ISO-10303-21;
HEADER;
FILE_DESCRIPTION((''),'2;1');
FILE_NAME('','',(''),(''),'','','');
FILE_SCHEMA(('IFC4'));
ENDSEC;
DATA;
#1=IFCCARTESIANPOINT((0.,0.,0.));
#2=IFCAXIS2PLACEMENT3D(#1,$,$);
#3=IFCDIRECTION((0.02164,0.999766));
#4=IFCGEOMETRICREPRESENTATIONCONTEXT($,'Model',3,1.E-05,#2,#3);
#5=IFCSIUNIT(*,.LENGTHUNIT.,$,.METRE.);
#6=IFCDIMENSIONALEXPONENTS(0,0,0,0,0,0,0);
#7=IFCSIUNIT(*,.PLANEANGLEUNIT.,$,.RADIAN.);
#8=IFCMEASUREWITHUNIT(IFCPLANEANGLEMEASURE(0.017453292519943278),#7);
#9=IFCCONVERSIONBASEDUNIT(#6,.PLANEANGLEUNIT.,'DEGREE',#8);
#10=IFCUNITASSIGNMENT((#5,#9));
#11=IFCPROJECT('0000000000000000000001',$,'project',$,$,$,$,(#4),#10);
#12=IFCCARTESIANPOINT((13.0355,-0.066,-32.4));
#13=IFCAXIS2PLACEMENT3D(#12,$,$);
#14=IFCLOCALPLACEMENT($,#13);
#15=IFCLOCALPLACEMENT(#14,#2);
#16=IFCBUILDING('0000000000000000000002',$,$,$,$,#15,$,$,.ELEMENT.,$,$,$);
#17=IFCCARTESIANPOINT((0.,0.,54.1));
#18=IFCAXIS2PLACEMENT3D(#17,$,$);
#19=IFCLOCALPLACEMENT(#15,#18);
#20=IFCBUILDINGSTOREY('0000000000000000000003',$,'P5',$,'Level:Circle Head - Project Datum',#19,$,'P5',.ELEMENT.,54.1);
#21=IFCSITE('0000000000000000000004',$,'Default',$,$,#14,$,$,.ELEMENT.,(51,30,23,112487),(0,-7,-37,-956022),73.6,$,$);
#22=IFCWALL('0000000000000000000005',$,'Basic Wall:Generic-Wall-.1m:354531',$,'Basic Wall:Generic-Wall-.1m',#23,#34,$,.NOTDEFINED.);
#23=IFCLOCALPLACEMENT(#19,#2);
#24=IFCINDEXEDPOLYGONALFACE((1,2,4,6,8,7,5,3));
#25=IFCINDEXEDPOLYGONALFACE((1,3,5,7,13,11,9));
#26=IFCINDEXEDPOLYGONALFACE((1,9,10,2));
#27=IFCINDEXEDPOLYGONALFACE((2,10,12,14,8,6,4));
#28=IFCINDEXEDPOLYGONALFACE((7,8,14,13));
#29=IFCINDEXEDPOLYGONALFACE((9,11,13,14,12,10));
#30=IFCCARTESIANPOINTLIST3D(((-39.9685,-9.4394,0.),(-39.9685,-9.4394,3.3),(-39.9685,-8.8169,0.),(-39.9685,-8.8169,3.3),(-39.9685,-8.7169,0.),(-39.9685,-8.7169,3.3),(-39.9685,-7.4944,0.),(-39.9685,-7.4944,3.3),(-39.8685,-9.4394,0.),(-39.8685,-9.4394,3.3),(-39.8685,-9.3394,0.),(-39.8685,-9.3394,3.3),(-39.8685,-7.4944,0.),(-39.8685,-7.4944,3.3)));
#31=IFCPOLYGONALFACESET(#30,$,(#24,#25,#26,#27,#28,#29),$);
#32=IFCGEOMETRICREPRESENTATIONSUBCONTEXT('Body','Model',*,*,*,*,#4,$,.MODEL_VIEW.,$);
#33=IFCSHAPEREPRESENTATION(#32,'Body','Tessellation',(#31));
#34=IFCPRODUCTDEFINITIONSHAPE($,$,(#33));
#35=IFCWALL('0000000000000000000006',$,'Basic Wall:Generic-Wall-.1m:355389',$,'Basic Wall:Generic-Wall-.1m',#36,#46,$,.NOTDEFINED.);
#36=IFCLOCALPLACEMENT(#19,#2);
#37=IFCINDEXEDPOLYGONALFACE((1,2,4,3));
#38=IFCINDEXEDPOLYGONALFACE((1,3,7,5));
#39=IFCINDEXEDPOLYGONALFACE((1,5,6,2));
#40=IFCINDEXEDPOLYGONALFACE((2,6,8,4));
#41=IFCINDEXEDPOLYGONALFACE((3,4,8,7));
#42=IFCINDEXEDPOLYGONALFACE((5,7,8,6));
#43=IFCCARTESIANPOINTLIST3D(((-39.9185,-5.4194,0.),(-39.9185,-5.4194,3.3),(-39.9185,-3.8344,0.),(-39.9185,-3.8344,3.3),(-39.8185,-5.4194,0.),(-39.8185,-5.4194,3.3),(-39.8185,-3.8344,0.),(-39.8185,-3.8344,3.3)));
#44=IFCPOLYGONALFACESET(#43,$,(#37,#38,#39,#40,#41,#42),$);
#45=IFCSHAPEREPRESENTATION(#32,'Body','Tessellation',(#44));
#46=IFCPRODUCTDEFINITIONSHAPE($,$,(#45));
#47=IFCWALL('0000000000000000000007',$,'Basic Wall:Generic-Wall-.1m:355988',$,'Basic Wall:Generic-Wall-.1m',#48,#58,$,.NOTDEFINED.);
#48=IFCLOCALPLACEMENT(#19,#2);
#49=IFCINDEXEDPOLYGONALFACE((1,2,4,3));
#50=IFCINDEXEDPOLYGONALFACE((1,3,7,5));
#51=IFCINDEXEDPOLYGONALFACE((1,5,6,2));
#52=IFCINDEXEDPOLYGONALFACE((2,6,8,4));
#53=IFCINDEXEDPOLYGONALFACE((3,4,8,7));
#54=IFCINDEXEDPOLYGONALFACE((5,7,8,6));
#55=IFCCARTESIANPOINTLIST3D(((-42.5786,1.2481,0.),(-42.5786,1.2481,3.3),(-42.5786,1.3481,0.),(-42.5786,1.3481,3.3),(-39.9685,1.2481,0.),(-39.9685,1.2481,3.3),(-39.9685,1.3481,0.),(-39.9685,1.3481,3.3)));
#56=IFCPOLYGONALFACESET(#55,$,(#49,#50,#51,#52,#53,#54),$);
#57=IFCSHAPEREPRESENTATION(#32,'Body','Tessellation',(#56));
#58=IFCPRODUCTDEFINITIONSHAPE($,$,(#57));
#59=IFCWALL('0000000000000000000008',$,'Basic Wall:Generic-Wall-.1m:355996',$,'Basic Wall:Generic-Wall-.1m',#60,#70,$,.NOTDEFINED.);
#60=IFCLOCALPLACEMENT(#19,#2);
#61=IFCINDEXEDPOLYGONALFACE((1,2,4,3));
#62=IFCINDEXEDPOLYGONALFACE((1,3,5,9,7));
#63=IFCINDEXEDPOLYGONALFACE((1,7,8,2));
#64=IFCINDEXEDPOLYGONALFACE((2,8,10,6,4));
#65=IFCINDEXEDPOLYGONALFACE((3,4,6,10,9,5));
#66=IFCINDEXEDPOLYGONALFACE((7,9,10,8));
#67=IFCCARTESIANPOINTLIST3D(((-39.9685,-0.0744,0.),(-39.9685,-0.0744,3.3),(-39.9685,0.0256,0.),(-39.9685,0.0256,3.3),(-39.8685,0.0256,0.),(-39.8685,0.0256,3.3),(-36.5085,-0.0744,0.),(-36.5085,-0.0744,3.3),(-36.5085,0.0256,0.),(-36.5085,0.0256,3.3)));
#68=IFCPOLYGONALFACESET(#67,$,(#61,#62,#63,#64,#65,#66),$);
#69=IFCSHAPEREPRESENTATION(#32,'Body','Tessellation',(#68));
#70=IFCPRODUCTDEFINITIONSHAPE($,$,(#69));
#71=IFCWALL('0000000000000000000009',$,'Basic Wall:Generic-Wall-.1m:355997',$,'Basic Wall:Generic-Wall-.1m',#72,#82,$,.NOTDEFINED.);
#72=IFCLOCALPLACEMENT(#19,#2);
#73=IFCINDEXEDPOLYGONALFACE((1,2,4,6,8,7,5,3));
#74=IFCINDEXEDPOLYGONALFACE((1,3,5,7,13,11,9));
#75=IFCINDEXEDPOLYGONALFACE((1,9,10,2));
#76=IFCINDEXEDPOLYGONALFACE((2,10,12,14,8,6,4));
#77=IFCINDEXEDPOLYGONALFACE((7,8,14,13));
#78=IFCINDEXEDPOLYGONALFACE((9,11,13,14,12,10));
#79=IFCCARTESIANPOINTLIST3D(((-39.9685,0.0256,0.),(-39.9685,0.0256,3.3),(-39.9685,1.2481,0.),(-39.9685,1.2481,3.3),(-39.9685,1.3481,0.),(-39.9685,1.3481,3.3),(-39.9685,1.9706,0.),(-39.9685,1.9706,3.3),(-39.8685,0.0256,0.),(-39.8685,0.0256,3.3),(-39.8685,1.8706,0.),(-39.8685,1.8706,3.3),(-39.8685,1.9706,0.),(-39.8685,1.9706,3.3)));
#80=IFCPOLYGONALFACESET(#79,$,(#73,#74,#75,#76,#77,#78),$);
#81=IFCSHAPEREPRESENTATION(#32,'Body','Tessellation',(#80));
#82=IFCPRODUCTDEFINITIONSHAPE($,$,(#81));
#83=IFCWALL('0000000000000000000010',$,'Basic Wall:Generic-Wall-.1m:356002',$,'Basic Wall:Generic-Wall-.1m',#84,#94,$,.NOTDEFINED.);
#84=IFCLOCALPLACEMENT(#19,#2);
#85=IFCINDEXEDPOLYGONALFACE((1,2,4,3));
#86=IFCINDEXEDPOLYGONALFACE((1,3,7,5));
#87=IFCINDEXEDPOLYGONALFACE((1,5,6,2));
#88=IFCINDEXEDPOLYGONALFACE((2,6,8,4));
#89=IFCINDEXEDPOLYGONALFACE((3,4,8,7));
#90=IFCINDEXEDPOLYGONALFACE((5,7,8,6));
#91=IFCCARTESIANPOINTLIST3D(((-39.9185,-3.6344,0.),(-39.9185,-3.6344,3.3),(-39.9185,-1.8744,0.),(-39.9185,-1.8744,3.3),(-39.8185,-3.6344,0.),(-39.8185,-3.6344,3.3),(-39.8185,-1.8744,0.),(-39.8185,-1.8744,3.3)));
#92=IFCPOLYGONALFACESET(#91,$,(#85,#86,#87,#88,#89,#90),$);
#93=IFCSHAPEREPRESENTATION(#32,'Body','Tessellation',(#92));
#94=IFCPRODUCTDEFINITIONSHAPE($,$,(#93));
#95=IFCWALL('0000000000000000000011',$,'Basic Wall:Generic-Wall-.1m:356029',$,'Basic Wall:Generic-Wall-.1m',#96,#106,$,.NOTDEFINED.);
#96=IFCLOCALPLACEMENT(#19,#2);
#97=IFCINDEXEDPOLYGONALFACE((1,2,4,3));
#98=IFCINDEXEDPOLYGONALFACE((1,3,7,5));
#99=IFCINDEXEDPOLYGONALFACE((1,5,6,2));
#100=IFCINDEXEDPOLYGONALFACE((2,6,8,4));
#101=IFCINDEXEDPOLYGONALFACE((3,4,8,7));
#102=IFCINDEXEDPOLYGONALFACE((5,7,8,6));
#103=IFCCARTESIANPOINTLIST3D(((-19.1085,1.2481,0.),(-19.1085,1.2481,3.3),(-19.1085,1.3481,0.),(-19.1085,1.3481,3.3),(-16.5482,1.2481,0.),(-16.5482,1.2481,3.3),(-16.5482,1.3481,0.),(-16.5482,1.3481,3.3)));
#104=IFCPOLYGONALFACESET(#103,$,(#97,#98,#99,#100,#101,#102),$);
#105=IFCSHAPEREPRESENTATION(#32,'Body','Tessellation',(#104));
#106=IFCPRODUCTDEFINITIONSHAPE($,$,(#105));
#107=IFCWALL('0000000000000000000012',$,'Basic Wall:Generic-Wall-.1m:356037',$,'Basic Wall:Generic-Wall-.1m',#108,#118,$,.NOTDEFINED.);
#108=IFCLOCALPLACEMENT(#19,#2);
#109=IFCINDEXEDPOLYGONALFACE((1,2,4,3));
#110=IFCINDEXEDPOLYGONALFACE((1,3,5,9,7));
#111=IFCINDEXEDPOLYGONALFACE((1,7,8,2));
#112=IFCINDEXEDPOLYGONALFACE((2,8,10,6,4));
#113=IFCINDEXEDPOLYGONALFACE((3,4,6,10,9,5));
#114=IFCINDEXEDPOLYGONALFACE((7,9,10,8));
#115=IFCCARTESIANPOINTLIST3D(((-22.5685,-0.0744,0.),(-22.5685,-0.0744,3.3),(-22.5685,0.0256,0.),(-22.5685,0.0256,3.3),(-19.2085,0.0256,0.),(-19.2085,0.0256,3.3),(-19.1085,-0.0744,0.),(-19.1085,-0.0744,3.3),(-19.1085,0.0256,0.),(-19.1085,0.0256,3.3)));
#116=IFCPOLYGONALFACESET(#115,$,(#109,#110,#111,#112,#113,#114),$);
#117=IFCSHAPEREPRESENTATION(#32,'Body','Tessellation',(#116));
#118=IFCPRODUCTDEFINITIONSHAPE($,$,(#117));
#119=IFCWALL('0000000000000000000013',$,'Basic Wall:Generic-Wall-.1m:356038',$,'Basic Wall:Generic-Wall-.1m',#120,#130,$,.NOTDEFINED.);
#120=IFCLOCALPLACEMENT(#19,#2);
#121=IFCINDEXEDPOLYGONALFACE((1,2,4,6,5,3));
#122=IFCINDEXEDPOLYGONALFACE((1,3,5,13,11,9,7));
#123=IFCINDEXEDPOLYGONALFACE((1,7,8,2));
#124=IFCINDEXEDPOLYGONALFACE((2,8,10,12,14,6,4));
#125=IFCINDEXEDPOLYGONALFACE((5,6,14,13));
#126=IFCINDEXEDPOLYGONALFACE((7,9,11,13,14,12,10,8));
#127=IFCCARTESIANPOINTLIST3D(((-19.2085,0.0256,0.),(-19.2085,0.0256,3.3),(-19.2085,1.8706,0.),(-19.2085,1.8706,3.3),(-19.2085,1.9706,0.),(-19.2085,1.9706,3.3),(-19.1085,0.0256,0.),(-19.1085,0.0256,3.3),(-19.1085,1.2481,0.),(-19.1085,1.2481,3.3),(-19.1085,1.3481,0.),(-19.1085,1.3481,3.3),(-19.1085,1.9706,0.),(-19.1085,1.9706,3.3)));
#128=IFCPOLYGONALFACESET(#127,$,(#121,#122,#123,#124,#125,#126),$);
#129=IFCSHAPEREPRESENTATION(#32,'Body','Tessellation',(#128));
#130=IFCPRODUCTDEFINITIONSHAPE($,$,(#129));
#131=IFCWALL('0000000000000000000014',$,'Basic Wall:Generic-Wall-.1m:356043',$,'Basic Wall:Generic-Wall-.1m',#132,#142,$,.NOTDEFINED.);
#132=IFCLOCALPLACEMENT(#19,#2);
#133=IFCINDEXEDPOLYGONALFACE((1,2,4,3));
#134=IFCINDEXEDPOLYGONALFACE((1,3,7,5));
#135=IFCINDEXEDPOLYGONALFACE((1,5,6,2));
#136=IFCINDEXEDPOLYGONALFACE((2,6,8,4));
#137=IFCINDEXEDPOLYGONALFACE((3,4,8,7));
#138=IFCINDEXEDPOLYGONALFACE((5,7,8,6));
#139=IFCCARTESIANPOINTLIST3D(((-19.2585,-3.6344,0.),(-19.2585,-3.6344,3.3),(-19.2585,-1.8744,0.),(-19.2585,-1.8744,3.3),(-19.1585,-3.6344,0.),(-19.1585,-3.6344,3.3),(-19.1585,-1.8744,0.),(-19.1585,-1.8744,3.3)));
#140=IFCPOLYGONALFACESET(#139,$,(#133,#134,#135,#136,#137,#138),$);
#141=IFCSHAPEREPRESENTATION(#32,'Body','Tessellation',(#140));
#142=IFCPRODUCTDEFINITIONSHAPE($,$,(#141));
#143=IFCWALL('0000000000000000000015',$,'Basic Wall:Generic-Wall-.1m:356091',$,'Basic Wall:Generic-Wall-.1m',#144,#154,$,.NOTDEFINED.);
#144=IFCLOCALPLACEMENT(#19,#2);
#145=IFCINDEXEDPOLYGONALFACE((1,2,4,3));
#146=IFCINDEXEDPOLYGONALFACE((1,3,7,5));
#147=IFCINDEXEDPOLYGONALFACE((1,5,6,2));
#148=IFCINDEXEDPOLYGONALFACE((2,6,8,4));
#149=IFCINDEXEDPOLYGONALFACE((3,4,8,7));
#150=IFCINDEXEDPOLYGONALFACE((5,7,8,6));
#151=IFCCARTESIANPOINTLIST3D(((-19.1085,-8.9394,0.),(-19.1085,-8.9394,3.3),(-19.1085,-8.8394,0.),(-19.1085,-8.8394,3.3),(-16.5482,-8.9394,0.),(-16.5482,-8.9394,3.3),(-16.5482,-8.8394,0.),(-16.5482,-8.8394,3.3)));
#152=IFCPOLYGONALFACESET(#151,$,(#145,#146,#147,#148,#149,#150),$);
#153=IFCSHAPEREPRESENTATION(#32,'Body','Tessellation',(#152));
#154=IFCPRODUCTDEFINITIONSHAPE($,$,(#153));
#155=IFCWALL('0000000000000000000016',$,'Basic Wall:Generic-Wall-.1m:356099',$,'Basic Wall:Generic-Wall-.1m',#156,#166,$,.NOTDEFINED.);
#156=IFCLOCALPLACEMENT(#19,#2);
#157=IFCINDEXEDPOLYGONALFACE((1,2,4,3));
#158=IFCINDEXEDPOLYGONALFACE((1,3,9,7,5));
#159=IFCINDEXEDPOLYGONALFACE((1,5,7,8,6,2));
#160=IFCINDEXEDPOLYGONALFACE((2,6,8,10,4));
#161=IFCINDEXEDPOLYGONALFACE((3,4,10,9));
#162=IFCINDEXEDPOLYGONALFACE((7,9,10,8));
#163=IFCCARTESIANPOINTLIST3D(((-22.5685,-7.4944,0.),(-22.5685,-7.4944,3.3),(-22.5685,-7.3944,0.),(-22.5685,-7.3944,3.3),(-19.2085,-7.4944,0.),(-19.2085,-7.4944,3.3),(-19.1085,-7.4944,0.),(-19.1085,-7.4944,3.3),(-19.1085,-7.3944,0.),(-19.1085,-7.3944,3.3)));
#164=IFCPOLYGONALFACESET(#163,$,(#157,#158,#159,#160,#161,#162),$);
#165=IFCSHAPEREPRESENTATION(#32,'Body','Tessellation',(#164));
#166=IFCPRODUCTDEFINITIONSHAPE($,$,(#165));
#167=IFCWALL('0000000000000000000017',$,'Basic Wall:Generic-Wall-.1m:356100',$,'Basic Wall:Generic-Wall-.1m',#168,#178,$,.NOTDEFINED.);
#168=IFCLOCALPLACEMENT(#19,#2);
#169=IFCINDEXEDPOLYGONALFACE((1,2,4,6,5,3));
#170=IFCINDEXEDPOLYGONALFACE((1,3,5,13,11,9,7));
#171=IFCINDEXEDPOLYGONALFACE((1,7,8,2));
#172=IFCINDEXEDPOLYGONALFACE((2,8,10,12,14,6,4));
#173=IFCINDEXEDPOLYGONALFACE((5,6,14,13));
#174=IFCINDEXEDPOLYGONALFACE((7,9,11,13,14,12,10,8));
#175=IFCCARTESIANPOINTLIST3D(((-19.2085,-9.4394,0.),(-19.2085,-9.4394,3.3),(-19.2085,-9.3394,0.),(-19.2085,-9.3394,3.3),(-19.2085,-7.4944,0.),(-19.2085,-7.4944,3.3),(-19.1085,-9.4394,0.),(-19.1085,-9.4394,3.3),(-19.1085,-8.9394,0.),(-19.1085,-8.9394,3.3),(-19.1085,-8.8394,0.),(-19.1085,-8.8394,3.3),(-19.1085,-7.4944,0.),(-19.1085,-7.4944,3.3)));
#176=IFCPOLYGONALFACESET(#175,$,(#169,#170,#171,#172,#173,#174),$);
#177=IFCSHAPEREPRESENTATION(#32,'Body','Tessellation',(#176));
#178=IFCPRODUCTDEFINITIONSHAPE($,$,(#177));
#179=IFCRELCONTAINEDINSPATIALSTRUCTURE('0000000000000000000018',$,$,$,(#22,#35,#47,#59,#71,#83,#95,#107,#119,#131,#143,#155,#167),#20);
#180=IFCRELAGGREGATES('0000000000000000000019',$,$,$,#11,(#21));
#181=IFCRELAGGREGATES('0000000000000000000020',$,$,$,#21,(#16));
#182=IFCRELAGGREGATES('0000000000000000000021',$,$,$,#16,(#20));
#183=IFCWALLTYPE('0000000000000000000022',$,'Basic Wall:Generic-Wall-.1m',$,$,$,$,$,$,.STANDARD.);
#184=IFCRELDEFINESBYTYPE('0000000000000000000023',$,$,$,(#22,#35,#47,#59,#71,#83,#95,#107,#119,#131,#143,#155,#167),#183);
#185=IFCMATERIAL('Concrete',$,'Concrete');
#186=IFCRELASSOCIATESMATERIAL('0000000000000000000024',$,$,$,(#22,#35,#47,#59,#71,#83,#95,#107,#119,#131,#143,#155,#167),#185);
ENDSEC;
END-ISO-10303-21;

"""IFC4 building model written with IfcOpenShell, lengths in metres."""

from ifc_helpers import new_model, entity, si_unit, converted_unit, direction, frame, origin, place, context, subcontext, project, spatial, indexed_curve, outline, extrude, material, type_object, element, save


model = new_model("IFC4")

# Units and contexts
model_context = context("Model", 3, precision=1e-05, world=origin(), true_north=direction((0.02164, 0.999766)))
body_context = subcontext(model_context, "Body", "Model", "MODEL_VIEW")
ifc_project = project(units=[si_unit("LENGTHUNIT", "METRE"), converted_unit("PLANEANGLEUNIT", "DEGREE", entity("IfcPlaneAngleMeasure", 0.017453292519943278), si_unit("PLANEANGLEUNIT", "RADIAN"), dimensions=[0, 0, 0, 0, 0, 0, 0])], contexts=[model_context])

# Site, building, storey
site_placement = place(None, frame((13.0355, -0.066, -32.4)))
site = spatial("IfcSite", under=ifc_project, at=site_placement, Name="Default", CompositionType="ELEMENT", RefLatitude=(51, 30, 23, 112487), RefLongitude=(0, -7, -37, -956022), RefElevation=73.6)
building_placement = place(site_placement, origin())
building = spatial("IfcBuilding", under=site, at=building_placement, CompositionType="ELEMENT")
storey_placement = place(building_placement, frame((0.0, 0.0, 54.1)))
storey = spatial("IfcBuildingStorey", under=building, at=storey_placement, Name="P5", ObjectType="Level:Circle Head - Project Datum", LongName="P5", CompositionType="ELEMENT", Elevation=54.1)

# Shared definitions
ifc_material = material(Name="Concrete", Category="Concrete")

# Walls
wall_type = type_object("IfcWallType", Name="Basic Wall:Generic-Wall-.1m", PredefinedType="STANDARD")
wall_1_placement = place(storey_placement, frame((-39.9185, -7.4944, 0.0), z_axis=(0.0, 0.0, 1.0), x_axis=(0.0, -1.0, 0.0)))
element("IfcWall", 1, at=wall_1_placement, inside=storey, type_object=wall_type, material=ifc_material, Name="Basic Wall:Generic-Wall-.1m:354531", ObjectType="Basic Wall:Generic-Wall-.1m", PredefinedType="NOTDEFINED", context=body_context, shape_type="SweptSolid", body=[
    extrude(outline(indexed_curve([(1.945, -0.05), (1.945, 0.05), (1.845, 0.05), (0.0, 0.05), (0.0, -0.05), (1.2225, -0.05), (1.3225, -0.05), (1.945, -0.05)], self_intersect=False)), origin(), (0.0, 0.0, 1.0), 3.3),
])
wall_2_placement = place(storey_placement, frame((-39.8685, -5.4194, 0.0), z_axis=(0.0, 0.0, 1.0), x_axis=(0.0, 1.0, 0.0)))
element("IfcWall", 2, at=wall_2_placement, inside=storey, type_object=wall_type, material=ifc_material, Name="Basic Wall:Generic-Wall-.1m:355389", ObjectType="Basic Wall:Generic-Wall-.1m", PredefinedType="NOTDEFINED", context=body_context, shape_type="SweptSolid", body=[
    extrude(outline(indexed_curve([(1.585, -0.05), (1.585, 0.05), (0.0, 0.05), (0.0, -0.05), (1.585, -0.05)], self_intersect=False)), origin(), (0.0, 0.0, 1.0), 3.3),
])
wall_3_placement = place(storey_placement, frame((-39.9685, 1.2981, 0.0), z_axis=(0.0, 0.0, 1.0), x_axis=(-1.0, 0.0, 0.0)))
element("IfcWall", 3, at=wall_3_placement, inside=storey, type_object=wall_type, material=ifc_material, Name="Basic Wall:Generic-Wall-.1m:355988", ObjectType="Basic Wall:Generic-Wall-.1m", PredefinedType="NOTDEFINED", context=body_context, shape_type="SweptSolid", body=[
    extrude(outline(indexed_curve([(2.6101, -0.05), (2.6101, 0.05), (0.0, 0.05), (0.0, -0.05), (2.6101, -0.05)], self_intersect=False)), origin(), (0.0, 0.0, 1.0), 3.3),
])
wall_4_placement = place(storey_placement, frame((-36.5085, -0.0244, 0.0), z_axis=(0.0, 0.0, 1.0), x_axis=(-1.0, 0.0, 0.0)))
element("IfcWall", 4, at=wall_4_placement, inside=storey, type_object=wall_type, material=ifc_material, Name="Basic Wall:Generic-Wall-.1m:355996", ObjectType="Basic Wall:Generic-Wall-.1m", PredefinedType="NOTDEFINED", context=body_context, shape_type="SweptSolid", body=[
    extrude(outline(indexed_curve([(3.46, -0.05), (3.46, 0.05), (0.0, 0.05), (0.0, -0.05), (3.36, -0.05), (3.46, -0.05)], self_intersect=False)), origin(), (0.0, 0.0, 1.0), 3.3),
])
wall_5_placement = place(storey_placement, frame((-39.9185, 0.0256, 0.0), z_axis=(0.0, 0.0, 1.0), x_axis=(0.0, 1.0, 0.0)))
element("IfcWall", 5, at=wall_5_placement, inside=storey, type_object=wall_type, material=ifc_material, Name="Basic Wall:Generic-Wall-.1m:355997", ObjectType="Basic Wall:Generic-Wall-.1m", PredefinedType="NOTDEFINED", context=body_context, shape_type="SweptSolid", body=[
    extrude(outline(indexed_curve([(1.945, -0.05), (1.945, 0.05), (1.3225, 0.05), (1.2225, 0.05), (0.0, 0.05), (0.0, -0.05), (1.845, -0.05), (1.945, -0.05)], self_intersect=False)), origin(), (0.0, 0.0, 1.0), 3.3),
])
wall_6_placement = place(storey_placement, frame((-39.8685, -1.8744, 0.0), z_axis=(0.0, 0.0, 1.0), x_axis=(0.0, -1.0, 0.0)))
element("IfcWall", 6, at=wall_6_placement, inside=storey, type_object=wall_type, material=ifc_material, Name="Basic Wall:Generic-Wall-.1m:356002", ObjectType="Basic Wall:Generic-Wall-.1m", PredefinedType="NOTDEFINED", context=body_context, shape_type="SweptSolid", body=[
    extrude(outline(indexed_curve([(1.76, -0.05), (1.76, 0.05), (0.0, 0.05), (0.0, -0.05), (1.76, -0.05)], self_intersect=False)), origin(), (0.0, 0.0, 1.0), 3.3),
])
wall_7_placement = place(storey_placement, frame((-19.1085, 1.2981, 0.0)))
element("IfcWall", 7, at=wall_7_placement, inside=storey, type_object=wall_type, material=ifc_material, Name="Basic Wall:Generic-Wall-.1m:356029", ObjectType="Basic Wall:Generic-Wall-.1m", PredefinedType="NOTDEFINED", context=body_context, shape_type="SweptSolid", body=[
    extrude(outline(indexed_curve([(2.5602, -0.05), (2.5602, 0.05), (0.0, 0.05), (0.0, -0.05), (2.5602, -0.05)], self_intersect=False)), origin(), (0.0, 0.0, 1.0), 3.3),
])
wall_8_placement = place(storey_placement, frame((-22.5685, -0.0244, 0.0)))
element("IfcWall", 8, at=wall_8_placement, inside=storey, type_object=wall_type, material=ifc_material, Name="Basic Wall:Generic-Wall-.1m:356037", ObjectType="Basic Wall:Generic-Wall-.1m", PredefinedType="NOTDEFINED", context=body_context, shape_type="SweptSolid", body=[
    extrude(outline(indexed_curve([(3.46, -0.05), (3.46, 0.05), (3.36, 0.05), (0.0, 0.05), (0.0, -0.05), (3.46, -0.05)], self_intersect=False)), origin(), (0.0, 0.0, 1.0), 3.3),
])
wall_9_placement = place(storey_placement, frame((-19.1585, 0.0256, 0.0), z_axis=(0.0, 0.0, 1.0), x_axis=(0.0, 1.0, 0.0)))
element("IfcWall", 9, at=wall_9_placement, inside=storey, type_object=wall_type, material=ifc_material, Name="Basic Wall:Generic-Wall-.1m:356038", ObjectType="Basic Wall:Generic-Wall-.1m", PredefinedType="NOTDEFINED", context=body_context, shape_type="SweptSolid", body=[
    extrude(outline(indexed_curve([(1.945, -0.05), (1.945, 0.05), (1.845, 0.05), (0.0, 0.05), (0.0, -0.05), (1.2225, -0.05), (1.3225, -0.05), (1.945, -0.05)], self_intersect=False)), origin(), (0.0, 0.0, 1.0), 3.3),
])
wall_10_placement = place(storey_placement, frame((-19.2085, -1.8744, 0.0), z_axis=(0.0, 0.0, 1.0), x_axis=(0.0, -1.0, 0.0)))
element("IfcWall", 10, at=wall_10_placement, inside=storey, type_object=wall_type, material=ifc_material, Name="Basic Wall:Generic-Wall-.1m:356043", ObjectType="Basic Wall:Generic-Wall-.1m", PredefinedType="NOTDEFINED", context=body_context, shape_type="SweptSolid", body=[
    extrude(outline(indexed_curve([(1.76, -0.05), (1.76, 0.05), (0.0, 0.05), (0.0, -0.05), (1.76, -0.05)], self_intersect=False)), origin(), (0.0, 0.0, 1.0), 3.3),
])
wall_11_placement = place(storey_placement, frame((-19.1085, -8.8894, 0.0)))
element("IfcWall", 11, at=wall_11_placement, inside=storey, type_object=wall_type, material=ifc_material, Name="Basic Wall:Generic-Wall-.1m:356091", ObjectType="Basic Wall:Generic-Wall-.1m", PredefinedType="NOTDEFINED", context=body_context, shape_type="SweptSolid", body=[
    extrude(outline(indexed_curve([(2.5602, -0.05), (2.5602, 0.05), (0.0, 0.05), (0.0, -0.05), (2.5602, -0.05)], self_intersect=False)), origin(), (0.0, 0.0, 1.0), 3.3),
])
wall_12_placement = place(storey_placement, frame((-22.5685, -7.4444, 0.0)))
element("IfcWall", 12, at=wall_12_placement, inside=storey, type_object=wall_type, material=ifc_material, Name="Basic Wall:Generic-Wall-.1m:356099", ObjectType="Basic Wall:Generic-Wall-.1m", PredefinedType="NOTDEFINED", context=body_context, shape_type="SweptSolid", body=[
    extrude(outline(indexed_curve([(3.46, -0.05), (3.46, 0.05), (0.0, 0.05), (0.0, -0.05), (3.36, -0.05), (3.46, -0.05)], self_intersect=False)), origin(), (0.0, 0.0, 1.0), 3.3),
])
wall_13_placement = place(storey_placement, frame((-19.1585, -7.4944, 0.0), z_axis=(0.0, 0.0, 1.0), x_axis=(0.0, -1.0, 0.0)))
element("IfcWall", 13, at=wall_13_placement, inside=storey, type_object=wall_type, material=ifc_material, Name="Basic Wall:Generic-Wall-.1m:356100", ObjectType="Basic Wall:Generic-Wall-.1m", PredefinedType="NOTDEFINED", context=body_context, shape_type="SweptSolid", body=[
    extrude(outline(indexed_curve([(1.945, -0.05), (1.945, 0.05), (1.445, 0.05), (1.345, 0.05), (0.0, 0.05), (0.0, -0.05), (1.845, -0.05), (1.945, -0.05)], self_intersect=False)), origin(), (0.0, 0.0, 1.0), 3.3),
])

save(model, "model.ifc")
